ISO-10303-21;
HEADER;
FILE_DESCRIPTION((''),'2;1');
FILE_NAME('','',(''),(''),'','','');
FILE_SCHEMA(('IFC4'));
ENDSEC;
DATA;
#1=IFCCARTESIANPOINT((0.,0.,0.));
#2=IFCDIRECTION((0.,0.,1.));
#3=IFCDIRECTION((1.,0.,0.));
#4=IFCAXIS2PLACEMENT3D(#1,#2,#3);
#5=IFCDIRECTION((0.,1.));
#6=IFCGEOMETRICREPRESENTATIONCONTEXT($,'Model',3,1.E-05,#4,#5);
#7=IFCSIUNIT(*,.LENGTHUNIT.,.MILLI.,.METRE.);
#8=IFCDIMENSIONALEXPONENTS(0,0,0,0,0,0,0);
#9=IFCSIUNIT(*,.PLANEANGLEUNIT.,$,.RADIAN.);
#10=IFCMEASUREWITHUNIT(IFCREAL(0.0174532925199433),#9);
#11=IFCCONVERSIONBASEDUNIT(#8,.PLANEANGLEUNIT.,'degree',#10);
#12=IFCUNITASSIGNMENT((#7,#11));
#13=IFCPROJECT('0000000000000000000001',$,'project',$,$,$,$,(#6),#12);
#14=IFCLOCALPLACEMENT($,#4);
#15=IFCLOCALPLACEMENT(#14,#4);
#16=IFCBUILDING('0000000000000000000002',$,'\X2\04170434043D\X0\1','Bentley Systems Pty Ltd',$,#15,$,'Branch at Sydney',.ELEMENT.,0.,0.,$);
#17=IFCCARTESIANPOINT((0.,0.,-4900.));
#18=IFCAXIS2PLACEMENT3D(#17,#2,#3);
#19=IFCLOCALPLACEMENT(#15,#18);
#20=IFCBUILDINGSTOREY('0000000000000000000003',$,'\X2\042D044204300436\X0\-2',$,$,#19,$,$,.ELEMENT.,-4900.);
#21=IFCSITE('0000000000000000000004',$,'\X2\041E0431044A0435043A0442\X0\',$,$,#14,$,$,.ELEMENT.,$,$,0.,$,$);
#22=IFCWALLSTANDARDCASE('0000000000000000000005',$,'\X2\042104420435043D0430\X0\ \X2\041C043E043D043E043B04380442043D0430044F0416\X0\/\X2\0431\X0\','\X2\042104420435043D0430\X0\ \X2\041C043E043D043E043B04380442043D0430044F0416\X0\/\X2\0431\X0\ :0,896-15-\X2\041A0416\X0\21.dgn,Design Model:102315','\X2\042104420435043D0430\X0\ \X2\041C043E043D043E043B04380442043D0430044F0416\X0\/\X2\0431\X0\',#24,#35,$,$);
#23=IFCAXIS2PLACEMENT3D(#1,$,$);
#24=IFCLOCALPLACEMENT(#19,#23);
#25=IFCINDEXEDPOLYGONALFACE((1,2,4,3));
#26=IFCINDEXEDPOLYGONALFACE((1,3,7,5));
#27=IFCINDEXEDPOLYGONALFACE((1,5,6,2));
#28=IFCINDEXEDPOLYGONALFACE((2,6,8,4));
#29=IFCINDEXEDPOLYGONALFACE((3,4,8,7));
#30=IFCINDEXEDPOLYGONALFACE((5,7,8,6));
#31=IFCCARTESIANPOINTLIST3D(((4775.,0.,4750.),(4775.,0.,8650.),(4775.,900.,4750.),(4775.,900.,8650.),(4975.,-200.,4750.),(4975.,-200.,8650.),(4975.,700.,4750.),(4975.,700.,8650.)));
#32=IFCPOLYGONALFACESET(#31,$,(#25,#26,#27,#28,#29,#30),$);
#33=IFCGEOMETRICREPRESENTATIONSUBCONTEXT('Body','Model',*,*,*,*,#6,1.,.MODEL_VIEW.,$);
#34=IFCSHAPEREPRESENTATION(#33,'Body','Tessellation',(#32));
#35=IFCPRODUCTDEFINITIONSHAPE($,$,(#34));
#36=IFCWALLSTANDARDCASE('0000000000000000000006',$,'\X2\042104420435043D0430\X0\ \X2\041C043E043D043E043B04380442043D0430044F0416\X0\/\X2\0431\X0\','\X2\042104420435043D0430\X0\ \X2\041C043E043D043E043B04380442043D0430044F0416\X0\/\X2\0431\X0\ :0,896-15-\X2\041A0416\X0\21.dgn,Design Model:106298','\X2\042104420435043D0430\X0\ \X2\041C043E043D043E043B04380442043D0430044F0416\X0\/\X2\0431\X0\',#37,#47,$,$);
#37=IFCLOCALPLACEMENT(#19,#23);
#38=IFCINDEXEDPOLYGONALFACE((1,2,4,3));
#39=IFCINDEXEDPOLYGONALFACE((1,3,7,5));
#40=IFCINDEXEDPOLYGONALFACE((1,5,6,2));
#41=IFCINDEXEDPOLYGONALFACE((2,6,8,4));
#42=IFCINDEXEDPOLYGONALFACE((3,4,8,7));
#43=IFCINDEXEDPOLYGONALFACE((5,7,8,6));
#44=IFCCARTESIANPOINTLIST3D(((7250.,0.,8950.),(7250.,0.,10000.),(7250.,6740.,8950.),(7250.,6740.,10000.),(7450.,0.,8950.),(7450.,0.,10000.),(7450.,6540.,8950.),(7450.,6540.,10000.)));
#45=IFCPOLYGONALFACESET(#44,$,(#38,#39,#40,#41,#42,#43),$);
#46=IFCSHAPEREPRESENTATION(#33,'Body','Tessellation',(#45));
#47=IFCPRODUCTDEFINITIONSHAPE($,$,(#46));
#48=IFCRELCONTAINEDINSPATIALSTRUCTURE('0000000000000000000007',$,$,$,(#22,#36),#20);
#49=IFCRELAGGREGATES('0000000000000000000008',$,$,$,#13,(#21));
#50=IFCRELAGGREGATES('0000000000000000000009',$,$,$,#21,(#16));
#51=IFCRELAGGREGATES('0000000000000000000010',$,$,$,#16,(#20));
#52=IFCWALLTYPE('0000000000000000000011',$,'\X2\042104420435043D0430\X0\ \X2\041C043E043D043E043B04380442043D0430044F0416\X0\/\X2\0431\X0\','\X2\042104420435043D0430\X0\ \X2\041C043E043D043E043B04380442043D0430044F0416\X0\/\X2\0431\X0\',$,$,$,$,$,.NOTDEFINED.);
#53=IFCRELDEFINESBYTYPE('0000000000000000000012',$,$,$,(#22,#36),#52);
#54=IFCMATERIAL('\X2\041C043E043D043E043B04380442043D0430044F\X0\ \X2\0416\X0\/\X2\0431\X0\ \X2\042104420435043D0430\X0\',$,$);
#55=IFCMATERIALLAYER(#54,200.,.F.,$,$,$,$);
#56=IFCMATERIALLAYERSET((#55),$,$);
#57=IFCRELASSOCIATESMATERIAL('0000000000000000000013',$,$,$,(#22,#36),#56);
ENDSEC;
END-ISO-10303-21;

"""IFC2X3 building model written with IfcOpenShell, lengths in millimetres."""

from ifc_helpers import new_model, entity, si_unit, converted_unit, direction, frame, origin_with_axes, place, context, subcontext, project, spatial, polyline, outline, extrude, material, layer, layer_set, layer_usage, type_object, element, save


model = new_model("IFC2X3")

# Units and contexts
model_context = context("Model", 3, precision=1e-05, world=origin_with_axes(), true_north=direction((0.0, 1.0)))
body_context = subcontext(model_context, "Body", "Model", "MODEL_VIEW", scale=1.0)
ifc_project = project(units=[si_unit("LENGTHUNIT", "METRE", prefix="MILLI"), converted_unit("PLANEANGLEUNIT", "degree", entity("IfcReal", 0.0174532925199433), si_unit("PLANEANGLEUNIT", "RADIAN"), dimensions=[0, 0, 0, 0, 0, 0, 0])], contexts=[model_context])

# Site, building, storey
site_placement = place(None, origin_with_axes())
site = spatial("IfcSite", under=ifc_project, at=site_placement, Name="Объект", CompositionType="ELEMENT", RefElevation=0.0)
building_placement = place(site_placement, origin_with_axes())
building = spatial("IfcBuilding", under=site, at=building_placement, Name="Здн1", Description="Bentley Systems Pty Ltd", LongName="Branch at Sydney", CompositionType="ELEMENT", ElevationOfRefHeight=0.0, ElevationOfTerrain=0.0)
storey_placement = place(building_placement, frame((0.0, 0.0, -4900.0), z_axis=(0.0, 0.0, 1.0), x_axis=(1.0, 0.0, 0.0)))
storey = spatial("IfcBuildingStorey", under=building, at=storey_placement, Name="Этаж-2", CompositionType="ELEMENT", Elevation=-4900.0)

# Shared definitions
ifc_material_1 = material(Name="Монолитная Ж/б Стена")
wall_type = type_object("IfcWallType", Name="Стена МонолитнаяЖ/б", Description="Стена МонолитнаяЖ/б", PredefinedType="NOTDEFINED")
ifc_layer_1 = layer(ifc_material_1, 200.0, ventilated=False)
ifc_layer_set_1 = layer_set([ifc_layer_1])
ifc_layer_usage_1 = layer_usage(ifc_layer_set_1, "AXIS2", "POSITIVE", 0.0)

# Walls
wall_1_placement = place(storey_placement, frame((4975.0, -200.0, 4750.0), z_axis=(0.0, 0.0, 1.0), x_axis=(0.0, 1.0, 0.0)))
element("IfcWallStandardCase", 1, at=wall_1_placement, inside=storey, type_object=wall_type, material=ifc_layer_usage_1, Name="Стена МонолитнаяЖ/б", Description="Стена МонолитнаяЖ/б :0,896-15-КЖ21.dgn,Design Model:102315", ObjectType="Стена МонолитнаяЖ/б", context=body_context, shape_type="SweptSolid", body=[
    extrude(outline(polyline([(1100.0, 200.0), (200.0, 200.0), (0.0, 0.0), (900.0, 0.0), (1100.0, 200.0)])), origin_with_axes(), (0.0, 0.0, 1.0), 3900.0),
])
wall_2_placement = place(storey_placement, frame((7250.0, 0.0, 8950.0), z_axis=(0.0, 0.0, 1.0), x_axis=(0.0, 1.0, 0.0)))
element("IfcWallStandardCase", 2, at=wall_2_placement, inside=storey, type_object=wall_type, material=ifc_layer_usage_1, Name="Стена МонолитнаяЖ/б", Description="Стена МонолитнаяЖ/б :0,896-15-КЖ21.dgn,Design Model:106298", ObjectType="Стена МонолитнаяЖ/б", context=body_context, shape_type="SweptSolid", body=[
    extrude(outline(polyline([(6740.0, 0.0), (0.0, 0.0), (0.0, -200.0), (6540.0, -200.0), (6740.0, 0.0)])), origin_with_axes(), (0.0, 0.0, 1.0), 1050.0),
])

save(model, "model.ifc")
